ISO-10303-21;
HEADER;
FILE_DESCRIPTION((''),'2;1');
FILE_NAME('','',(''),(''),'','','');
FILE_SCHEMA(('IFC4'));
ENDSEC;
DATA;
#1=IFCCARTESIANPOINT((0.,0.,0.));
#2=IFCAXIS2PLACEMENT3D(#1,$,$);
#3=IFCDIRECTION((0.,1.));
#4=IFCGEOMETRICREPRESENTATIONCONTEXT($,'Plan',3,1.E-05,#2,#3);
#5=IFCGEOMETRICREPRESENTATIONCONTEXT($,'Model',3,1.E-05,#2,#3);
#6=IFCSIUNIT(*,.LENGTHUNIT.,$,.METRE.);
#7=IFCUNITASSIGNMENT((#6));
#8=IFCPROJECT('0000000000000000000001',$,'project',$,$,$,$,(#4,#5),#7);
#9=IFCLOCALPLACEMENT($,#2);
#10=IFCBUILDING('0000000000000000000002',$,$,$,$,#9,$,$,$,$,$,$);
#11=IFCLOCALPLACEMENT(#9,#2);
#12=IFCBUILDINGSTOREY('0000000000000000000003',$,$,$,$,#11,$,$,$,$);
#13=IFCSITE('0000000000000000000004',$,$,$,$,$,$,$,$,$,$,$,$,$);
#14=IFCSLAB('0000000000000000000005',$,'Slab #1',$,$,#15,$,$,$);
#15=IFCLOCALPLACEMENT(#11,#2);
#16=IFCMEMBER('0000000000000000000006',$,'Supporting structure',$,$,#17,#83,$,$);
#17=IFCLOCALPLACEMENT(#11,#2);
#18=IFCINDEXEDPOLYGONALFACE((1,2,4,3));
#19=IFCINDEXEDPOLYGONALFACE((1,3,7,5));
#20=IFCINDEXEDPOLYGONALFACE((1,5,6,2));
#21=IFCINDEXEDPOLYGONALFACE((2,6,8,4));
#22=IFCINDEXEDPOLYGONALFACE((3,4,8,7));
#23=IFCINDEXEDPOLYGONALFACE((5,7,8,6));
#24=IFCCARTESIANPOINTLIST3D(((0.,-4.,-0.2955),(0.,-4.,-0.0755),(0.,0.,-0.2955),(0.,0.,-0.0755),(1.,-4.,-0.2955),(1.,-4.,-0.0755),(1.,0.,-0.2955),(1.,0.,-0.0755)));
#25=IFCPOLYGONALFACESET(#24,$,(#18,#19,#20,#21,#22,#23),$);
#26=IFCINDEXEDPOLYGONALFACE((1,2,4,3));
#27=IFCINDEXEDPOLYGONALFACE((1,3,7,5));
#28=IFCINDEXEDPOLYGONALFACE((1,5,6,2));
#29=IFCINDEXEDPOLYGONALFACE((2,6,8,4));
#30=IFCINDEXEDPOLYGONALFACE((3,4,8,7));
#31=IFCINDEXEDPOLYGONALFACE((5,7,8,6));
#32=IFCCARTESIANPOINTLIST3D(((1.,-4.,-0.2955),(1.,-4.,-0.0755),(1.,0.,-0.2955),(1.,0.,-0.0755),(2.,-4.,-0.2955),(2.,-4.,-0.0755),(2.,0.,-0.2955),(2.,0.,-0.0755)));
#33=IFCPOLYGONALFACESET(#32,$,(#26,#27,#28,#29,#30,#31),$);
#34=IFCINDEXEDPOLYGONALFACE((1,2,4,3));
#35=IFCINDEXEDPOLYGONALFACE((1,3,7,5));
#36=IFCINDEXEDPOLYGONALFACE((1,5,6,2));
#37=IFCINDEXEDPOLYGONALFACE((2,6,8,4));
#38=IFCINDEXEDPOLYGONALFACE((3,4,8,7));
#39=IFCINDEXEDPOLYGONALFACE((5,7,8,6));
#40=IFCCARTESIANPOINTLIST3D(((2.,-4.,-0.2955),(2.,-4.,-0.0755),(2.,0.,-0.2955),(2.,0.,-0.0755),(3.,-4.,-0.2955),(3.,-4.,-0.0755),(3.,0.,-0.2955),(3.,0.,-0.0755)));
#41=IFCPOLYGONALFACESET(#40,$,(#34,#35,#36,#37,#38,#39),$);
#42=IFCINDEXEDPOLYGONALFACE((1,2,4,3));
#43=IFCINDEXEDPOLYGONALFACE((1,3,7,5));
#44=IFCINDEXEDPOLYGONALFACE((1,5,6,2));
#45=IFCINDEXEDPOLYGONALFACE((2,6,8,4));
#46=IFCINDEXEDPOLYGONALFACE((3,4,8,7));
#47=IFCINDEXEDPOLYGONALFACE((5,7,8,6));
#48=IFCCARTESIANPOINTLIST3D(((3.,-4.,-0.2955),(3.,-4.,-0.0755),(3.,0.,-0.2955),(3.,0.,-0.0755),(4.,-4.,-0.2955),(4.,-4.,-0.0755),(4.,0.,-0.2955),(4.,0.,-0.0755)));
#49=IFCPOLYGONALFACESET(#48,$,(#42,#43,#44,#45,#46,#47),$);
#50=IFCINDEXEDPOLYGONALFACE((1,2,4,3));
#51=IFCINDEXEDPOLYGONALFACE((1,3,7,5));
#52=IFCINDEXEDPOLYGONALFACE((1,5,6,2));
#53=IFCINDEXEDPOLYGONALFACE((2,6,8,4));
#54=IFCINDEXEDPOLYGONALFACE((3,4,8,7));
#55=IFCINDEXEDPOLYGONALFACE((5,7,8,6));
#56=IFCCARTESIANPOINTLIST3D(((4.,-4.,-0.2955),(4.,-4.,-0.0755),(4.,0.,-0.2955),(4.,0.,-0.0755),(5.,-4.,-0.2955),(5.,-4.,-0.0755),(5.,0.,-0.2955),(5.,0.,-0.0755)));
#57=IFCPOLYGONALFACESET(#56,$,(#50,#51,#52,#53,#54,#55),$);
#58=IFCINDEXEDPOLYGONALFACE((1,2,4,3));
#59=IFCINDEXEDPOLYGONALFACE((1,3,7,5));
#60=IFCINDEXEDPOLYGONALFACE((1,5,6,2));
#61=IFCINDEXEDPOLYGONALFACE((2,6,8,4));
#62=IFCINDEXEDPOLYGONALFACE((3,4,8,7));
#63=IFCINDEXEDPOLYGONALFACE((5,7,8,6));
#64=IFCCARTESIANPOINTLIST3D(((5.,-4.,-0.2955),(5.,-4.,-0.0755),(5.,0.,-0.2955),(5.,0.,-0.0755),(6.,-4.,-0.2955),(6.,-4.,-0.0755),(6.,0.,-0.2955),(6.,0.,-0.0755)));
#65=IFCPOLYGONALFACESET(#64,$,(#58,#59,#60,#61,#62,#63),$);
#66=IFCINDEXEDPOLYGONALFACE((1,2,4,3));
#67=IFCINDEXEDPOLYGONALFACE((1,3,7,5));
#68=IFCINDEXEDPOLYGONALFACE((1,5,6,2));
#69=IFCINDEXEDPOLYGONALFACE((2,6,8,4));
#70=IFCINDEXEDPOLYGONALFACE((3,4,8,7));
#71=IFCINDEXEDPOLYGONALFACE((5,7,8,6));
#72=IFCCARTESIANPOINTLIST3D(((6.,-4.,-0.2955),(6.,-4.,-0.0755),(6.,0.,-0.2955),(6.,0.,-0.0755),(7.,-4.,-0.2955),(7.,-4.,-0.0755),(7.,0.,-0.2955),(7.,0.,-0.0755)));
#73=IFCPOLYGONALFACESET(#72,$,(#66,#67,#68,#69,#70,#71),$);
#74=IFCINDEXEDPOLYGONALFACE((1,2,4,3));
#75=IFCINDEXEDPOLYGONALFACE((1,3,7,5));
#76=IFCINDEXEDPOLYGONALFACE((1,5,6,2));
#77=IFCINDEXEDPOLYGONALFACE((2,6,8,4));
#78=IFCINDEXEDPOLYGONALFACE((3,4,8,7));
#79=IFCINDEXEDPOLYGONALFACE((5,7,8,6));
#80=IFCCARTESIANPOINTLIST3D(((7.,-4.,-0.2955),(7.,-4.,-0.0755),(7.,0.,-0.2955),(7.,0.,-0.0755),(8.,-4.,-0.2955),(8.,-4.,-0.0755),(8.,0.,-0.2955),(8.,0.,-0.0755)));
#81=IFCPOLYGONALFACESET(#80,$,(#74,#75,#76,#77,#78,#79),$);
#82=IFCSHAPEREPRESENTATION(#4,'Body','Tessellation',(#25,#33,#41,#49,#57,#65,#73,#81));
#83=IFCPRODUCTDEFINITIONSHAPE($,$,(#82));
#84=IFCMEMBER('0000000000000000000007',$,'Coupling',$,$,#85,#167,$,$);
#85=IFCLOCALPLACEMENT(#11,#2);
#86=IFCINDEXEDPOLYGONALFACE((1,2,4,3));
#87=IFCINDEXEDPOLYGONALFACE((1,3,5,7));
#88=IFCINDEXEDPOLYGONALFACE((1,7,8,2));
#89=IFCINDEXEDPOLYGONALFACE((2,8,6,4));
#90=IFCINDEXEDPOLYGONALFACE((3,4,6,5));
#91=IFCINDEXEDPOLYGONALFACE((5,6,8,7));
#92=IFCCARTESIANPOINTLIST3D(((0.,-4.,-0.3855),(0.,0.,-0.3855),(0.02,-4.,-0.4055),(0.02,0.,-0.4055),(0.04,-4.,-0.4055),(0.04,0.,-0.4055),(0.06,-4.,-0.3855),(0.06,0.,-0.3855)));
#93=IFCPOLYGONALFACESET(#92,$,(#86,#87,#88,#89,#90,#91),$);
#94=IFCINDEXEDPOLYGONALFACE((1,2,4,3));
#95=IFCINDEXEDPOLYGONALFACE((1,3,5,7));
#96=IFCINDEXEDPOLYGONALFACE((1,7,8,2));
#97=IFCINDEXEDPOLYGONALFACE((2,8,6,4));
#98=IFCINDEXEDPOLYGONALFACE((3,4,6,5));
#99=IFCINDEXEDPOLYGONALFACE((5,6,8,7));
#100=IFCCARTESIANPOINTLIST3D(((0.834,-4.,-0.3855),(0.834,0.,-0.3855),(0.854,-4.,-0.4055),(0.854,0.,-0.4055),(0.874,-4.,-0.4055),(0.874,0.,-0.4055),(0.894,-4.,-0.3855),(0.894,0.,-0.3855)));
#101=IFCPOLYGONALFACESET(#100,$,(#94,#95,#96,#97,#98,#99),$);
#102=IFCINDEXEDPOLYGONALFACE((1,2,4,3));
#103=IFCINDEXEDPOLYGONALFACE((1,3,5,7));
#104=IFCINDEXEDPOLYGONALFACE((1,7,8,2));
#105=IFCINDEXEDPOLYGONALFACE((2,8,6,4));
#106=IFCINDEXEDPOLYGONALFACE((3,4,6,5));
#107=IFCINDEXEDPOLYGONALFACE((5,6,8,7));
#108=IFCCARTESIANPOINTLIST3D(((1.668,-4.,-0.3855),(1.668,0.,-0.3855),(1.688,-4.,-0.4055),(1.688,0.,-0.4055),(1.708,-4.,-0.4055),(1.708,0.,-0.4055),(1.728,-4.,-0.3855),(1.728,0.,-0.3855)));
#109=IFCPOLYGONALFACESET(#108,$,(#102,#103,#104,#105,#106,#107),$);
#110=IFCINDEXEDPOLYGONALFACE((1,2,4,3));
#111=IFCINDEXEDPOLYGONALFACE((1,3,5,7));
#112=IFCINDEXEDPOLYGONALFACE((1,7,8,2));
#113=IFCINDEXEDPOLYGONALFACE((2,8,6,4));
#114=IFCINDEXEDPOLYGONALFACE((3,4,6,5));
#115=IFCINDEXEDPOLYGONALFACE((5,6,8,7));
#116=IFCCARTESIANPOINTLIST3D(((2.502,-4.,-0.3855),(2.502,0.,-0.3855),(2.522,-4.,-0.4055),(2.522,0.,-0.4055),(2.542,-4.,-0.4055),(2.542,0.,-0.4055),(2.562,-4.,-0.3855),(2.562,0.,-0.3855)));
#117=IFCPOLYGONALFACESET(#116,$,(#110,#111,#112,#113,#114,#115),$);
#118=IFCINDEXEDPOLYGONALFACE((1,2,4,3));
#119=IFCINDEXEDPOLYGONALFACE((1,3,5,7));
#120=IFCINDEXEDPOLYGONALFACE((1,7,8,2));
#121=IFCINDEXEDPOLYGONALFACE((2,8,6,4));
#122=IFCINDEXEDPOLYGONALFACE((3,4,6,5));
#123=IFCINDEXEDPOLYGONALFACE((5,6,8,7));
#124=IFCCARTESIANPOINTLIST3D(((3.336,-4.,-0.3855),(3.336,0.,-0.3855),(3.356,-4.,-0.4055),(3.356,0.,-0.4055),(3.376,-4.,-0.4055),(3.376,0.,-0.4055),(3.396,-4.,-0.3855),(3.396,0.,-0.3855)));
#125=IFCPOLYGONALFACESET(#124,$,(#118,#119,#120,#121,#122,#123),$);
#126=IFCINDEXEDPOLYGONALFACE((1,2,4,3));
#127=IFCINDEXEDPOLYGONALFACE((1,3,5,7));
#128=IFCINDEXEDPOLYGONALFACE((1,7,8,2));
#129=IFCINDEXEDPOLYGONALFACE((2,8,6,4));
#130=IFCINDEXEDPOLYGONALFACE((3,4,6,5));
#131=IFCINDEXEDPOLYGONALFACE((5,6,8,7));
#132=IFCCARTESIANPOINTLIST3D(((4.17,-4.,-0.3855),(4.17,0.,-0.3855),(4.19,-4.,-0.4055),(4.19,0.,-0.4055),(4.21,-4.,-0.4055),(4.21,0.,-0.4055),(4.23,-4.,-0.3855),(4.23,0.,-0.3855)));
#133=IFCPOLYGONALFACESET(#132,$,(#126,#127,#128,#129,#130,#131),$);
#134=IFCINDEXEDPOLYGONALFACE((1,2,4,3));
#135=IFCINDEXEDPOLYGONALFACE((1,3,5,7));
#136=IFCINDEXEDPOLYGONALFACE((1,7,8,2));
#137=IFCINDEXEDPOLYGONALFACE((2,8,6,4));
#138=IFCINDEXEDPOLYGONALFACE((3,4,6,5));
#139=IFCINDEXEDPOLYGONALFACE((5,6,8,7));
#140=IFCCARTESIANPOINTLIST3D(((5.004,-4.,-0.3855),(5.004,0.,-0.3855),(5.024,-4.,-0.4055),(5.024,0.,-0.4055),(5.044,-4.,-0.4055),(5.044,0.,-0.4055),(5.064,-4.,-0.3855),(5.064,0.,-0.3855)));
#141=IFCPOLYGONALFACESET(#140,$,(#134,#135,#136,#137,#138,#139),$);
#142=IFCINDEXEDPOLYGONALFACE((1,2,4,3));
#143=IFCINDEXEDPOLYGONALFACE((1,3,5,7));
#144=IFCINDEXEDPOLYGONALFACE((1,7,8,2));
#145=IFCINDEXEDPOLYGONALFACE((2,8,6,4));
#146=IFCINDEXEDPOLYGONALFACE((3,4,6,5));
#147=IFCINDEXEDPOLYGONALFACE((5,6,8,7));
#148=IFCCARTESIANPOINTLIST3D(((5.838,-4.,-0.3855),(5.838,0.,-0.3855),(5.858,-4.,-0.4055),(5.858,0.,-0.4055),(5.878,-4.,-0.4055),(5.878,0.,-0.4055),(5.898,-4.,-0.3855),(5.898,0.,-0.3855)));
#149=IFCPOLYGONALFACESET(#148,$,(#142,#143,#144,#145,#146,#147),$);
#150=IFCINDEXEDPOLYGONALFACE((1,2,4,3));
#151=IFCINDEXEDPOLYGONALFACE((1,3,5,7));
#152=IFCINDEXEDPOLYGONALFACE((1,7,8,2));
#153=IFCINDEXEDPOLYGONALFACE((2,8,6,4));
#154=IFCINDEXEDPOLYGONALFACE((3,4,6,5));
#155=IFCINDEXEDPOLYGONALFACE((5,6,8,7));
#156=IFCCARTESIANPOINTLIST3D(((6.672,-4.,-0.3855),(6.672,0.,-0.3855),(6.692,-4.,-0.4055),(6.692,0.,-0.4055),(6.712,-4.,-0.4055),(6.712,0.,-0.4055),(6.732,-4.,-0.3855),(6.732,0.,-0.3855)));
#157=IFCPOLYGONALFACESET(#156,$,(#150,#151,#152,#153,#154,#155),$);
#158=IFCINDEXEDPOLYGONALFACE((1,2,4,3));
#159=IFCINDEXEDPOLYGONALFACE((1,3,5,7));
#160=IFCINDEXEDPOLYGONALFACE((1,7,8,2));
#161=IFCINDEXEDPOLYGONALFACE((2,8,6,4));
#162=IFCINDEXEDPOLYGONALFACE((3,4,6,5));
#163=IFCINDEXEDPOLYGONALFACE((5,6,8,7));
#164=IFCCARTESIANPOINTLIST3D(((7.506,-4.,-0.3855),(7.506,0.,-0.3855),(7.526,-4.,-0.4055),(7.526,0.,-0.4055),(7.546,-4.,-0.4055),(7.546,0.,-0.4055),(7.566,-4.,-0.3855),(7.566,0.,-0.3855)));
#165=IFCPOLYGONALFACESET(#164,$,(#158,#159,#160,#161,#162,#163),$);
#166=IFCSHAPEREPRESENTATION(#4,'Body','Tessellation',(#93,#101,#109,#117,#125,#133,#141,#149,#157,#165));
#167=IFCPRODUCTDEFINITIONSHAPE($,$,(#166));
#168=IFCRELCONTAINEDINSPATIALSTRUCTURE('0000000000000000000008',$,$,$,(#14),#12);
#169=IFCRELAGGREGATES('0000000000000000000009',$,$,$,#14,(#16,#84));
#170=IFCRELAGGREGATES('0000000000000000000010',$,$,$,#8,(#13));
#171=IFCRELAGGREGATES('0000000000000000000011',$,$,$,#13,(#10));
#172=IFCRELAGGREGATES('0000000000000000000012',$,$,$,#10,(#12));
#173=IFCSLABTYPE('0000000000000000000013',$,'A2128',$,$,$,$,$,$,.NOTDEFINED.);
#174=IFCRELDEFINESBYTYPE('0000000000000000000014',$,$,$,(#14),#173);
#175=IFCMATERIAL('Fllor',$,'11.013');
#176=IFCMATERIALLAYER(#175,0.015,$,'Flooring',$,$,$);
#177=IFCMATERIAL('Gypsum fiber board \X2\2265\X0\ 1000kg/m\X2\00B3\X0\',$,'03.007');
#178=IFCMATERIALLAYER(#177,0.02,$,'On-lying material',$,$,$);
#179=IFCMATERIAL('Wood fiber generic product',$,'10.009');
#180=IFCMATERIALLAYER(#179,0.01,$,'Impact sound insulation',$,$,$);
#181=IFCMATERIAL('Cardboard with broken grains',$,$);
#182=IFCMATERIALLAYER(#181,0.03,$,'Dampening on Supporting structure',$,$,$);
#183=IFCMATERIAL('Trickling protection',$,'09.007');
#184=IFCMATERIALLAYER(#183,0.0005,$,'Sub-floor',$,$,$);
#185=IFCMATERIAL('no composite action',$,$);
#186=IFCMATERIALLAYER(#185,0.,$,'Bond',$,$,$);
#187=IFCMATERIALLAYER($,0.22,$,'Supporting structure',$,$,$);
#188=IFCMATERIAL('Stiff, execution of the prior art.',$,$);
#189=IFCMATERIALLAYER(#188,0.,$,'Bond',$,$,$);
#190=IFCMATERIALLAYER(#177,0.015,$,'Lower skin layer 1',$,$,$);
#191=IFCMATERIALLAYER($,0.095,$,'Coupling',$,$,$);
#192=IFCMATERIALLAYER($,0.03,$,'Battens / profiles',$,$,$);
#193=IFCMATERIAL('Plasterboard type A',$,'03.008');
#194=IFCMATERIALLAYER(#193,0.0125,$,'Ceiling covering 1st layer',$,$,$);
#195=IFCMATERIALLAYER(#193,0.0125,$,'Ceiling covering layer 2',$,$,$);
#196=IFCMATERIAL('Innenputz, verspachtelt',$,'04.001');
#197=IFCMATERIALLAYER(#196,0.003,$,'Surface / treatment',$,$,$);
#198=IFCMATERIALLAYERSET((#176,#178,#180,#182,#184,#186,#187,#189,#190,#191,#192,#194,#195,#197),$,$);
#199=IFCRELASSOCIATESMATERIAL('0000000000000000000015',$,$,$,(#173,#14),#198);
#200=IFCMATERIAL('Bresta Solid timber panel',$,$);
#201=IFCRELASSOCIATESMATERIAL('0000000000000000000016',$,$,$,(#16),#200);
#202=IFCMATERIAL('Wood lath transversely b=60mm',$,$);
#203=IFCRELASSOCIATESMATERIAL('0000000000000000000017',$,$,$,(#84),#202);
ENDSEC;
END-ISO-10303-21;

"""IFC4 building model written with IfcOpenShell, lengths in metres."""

from ifc_helpers import new_model, si_unit, direction, frame, frame_2d, origin, place, context, project, spatial, polyline, rectangle, outline, extrude, material, layer, layer_set, type_object, element, aggregate, save


model = new_model("IFC4")

# Units and contexts
plan_context = context("Plan", 3, precision=1e-05, world=origin(), true_north=direction((0.0, 1.0)))
model_context = context("Model", 3, precision=1e-05, world=origin(), true_north=direction((0.0, 1.0)))
ifc_project = project(units=[si_unit("LENGTHUNIT", "METRE")], contexts=[plan_context, model_context])

# Site, building, storey
site = spatial("IfcSite", under=ifc_project)
building_placement = place(None, origin())
building = spatial("IfcBuilding", under=site, at=building_placement)
storey_placement = place(building_placement, origin())
storey = spatial("IfcBuildingStorey", under=building, at=storey_placement)

# Slab, members
ifc_material_1 = material(Name="Fllor", Category="11.013")
ifc_layer_1 = layer(ifc_material_1, 0.015, Name="Flooring")
ifc_material_2 = material(Name="Gypsum fiber board ≥ 1000kg/m³", Category="03.007")
ifc_layer_2 = layer(ifc_material_2, 0.02, Name="On-lying material")
ifc_material_3 = material(Name="Wood fiber generic product", Category="10.009")
ifc_layer_3 = layer(ifc_material_3, 0.01, Name="Impact sound insulation")
ifc_material_4 = material(Name="Cardboard with broken grains")
ifc_layer_4 = layer(ifc_material_4, 0.03, Name="Dampening on Supporting structure")
ifc_material_5 = material(Name="Trickling protection", Category="09.007")
ifc_layer_5 = layer(ifc_material_5, 0.0005, Name="Sub-floor")
ifc_material_6 = material(Name="no composite action")
ifc_layer_6 = layer(ifc_material_6, 0.0, Name="Bond")
ifc_layer_7 = layer(None, 0.22, Name="Supporting structure")
ifc_material_7 = material(Name="Stiff, execution of the prior art.")
ifc_layer_8 = layer(ifc_material_7, 0.0, Name="Bond")
ifc_layer_9 = layer(ifc_material_2, 0.015, Name="Lower skin layer 1")
ifc_layer_10 = layer(None, 0.095, Name="Coupling")
ifc_layer_11 = layer(None, 0.03, Name="Battens / profiles")
ifc_material_8 = material(Name="Plasterboard type A", Category="03.008")
ifc_layer_12 = layer(ifc_material_8, 0.0125, Name="Ceiling covering 1st layer")
ifc_layer_13 = layer(ifc_material_8, 0.0125, Name="Ceiling covering layer 2")
ifc_material_9 = material(Name="Innenputz, verspachtelt", Category="04.001")
ifc_layer_14 = layer(ifc_material_9, 0.003, Name="Surface / treatment")
ifc_layer_set = layer_set([ifc_layer_1, ifc_layer_2, ifc_layer_3, ifc_layer_4, ifc_layer_5, ifc_layer_6, ifc_layer_7, ifc_layer_8, ifc_layer_9, ifc_layer_10, ifc_layer_11, ifc_layer_12, ifc_layer_13, ifc_layer_14])
slab_type = type_object("IfcSlabType", Name="A2128", PredefinedType="NOTDEFINED", material=ifc_layer_set)
slab_placement = place(None, frame((0.0, 0.0, 0.0), z_axis=(0.0, 0.0, -1.0), x_axis=(1.0, 0.0, 0.0)))
slab = element("IfcSlab", 1, at=slab_placement, inside=storey, type_object=slab_type, material=ifc_layer_set, Name="Slab #1")
ifc_material_10 = material(Name="Bresta Solid timber panel")
member_1_placement = place(slab_placement, origin())
member_1 = element("IfcMember", 2, at=member_1_placement, material=ifc_material_10, Name="Supporting structure", context=plan_context, shape_type="SweptSolid", body=[
    extrude(rectangle(XDim=1.0, YDim=0.22, at=frame_2d((0.5, 0.11), x_axis=(1.0, 0.0))), frame((0.0, 4.0, 0.0755), z_axis=(0.0, -1.0, 0.0), x_axis=(1.0, 0.0, 0.0)), (0.0, 0.0, 1.0), 4.0),
    extrude(rectangle(XDim=1.0, YDim=0.22, at=frame_2d((0.5, 0.11), x_axis=(1.0, 0.0))), frame((1.0, 4.0, 0.0755), z_axis=(0.0, -1.0, 0.0), x_axis=(1.0, 0.0, 0.0)), (0.0, 0.0, 1.0), 4.0),
    extrude(rectangle(XDim=1.0, YDim=0.22, at=frame_2d((0.5, 0.11), x_axis=(1.0, 0.0))), frame((2.0, 4.0, 0.0755), z_axis=(0.0, -1.0, 0.0), x_axis=(1.0, 0.0, 0.0)), (0.0, 0.0, 1.0), 4.0),
    extrude(rectangle(XDim=1.0, YDim=0.22, at=frame_2d((0.5, 0.11), x_axis=(1.0, 0.0))), frame((3.0, 4.0, 0.0755), z_axis=(0.0, -1.0, 0.0), x_axis=(1.0, 0.0, 0.0)), (0.0, 0.0, 1.0), 4.0),
    extrude(rectangle(XDim=1.0, YDim=0.22, at=frame_2d((0.5, 0.11), x_axis=(1.0, 0.0))), frame((4.0, 4.0, 0.0755), z_axis=(0.0, -1.0, 0.0), x_axis=(1.0, 0.0, 0.0)), (0.0, 0.0, 1.0), 4.0),
    extrude(rectangle(XDim=1.0, YDim=0.22, at=frame_2d((0.5, 0.11), x_axis=(1.0, 0.0))), frame((5.0, 4.0, 0.0755), z_axis=(0.0, -1.0, 0.0), x_axis=(1.0, 0.0, 0.0)), (0.0, 0.0, 1.0), 4.0),
    extrude(rectangle(XDim=1.0, YDim=0.22, at=frame_2d((0.5, 0.11), x_axis=(1.0, 0.0))), frame((6.0, 4.0, 0.0755), z_axis=(0.0, -1.0, 0.0), x_axis=(1.0, 0.0, 0.0)), (0.0, 0.0, 1.0), 4.0),
    extrude(rectangle(XDim=1.0, YDim=0.22, at=frame_2d((0.5, 0.11), x_axis=(1.0, 0.0))), frame((7.0, 4.0, 0.0755), z_axis=(0.0, -1.0, 0.0), x_axis=(1.0, 0.0, 0.0)), (0.0, 0.0, 1.0), 4.0),
])
ifc_material_11 = material(Name="Wood lath transversely b=60mm")
member_2_placement = place(slab_placement, origin())
member_2 = element("IfcMember", 3, at=member_2_placement, material=ifc_material_11, Name="Coupling", context=plan_context, shape_type="SweptSolid", body=[
    extrude(outline(polyline([(0.0, 0.0), (0.06, 0.0), (0.04, 0.02), (0.02, 0.02), (0.0, 0.0)])), frame((0.0, 4.0, 0.3855), z_axis=(0.0, -1.0, 0.0), x_axis=(1.0, 0.0, 0.0)), (0.0, 0.0, 1.0), 4.0),
    extrude(outline(polyline([(0.0, 0.0), (0.06, 0.0), (0.04, 0.02), (0.02, 0.02), (0.0, 0.0)])), frame((0.834, 4.0, 0.3855), z_axis=(0.0, -1.0, 0.0), x_axis=(1.0, 0.0, 0.0)), (0.0, 0.0, 1.0), 4.0),
    extrude(outline(polyline([(0.0, 0.0), (0.06, 0.0), (0.04, 0.02), (0.02, 0.02), (0.0, 0.0)])), frame((1.668, 4.0, 0.3855), z_axis=(0.0, -1.0, 0.0), x_axis=(1.0, 0.0, 0.0)), (0.0, 0.0, 1.0), 4.0),
    extrude(outline(polyline([(0.0, 0.0), (0.06, 0.0), (0.04, 0.02), (0.02, 0.02), (0.0, 0.0)])), frame((2.502, 4.0, 0.3855), z_axis=(0.0, -1.0, 0.0), x_axis=(1.0, 0.0, 0.0)), (0.0, 0.0, 1.0), 4.0),
    extrude(outline(polyline([(0.0, 0.0), (0.06, 0.0), (0.04, 0.02), (0.02, 0.02), (0.0, 0.0)])), frame((3.336, 4.0, 0.3855), z_axis=(0.0, -1.0, 0.0), x_axis=(1.0, 0.0, 0.0)), (0.0, 0.0, 1.0), 4.0),
    extrude(outline(polyline([(0.0, 0.0), (0.06, 0.0), (0.04, 0.02), (0.02, 0.02), (0.0, 0.0)])), frame((4.17, 4.0, 0.3855), z_axis=(0.0, -1.0, 0.0), x_axis=(1.0, 0.0, 0.0)), (0.0, 0.0, 1.0), 4.0),
    extrude(outline(polyline([(0.0, 0.0), (0.06, 0.0), (0.04, 0.02), (0.02, 0.02), (0.0, 0.0)])), frame((5.004, 4.0, 0.3855), z_axis=(0.0, -1.0, 0.0), x_axis=(1.0, 0.0, 0.0)), (0.0, 0.0, 1.0), 4.0),
    extrude(outline(polyline([(0.0, 0.0), (0.06, 0.0), (0.04, 0.02), (0.02, 0.02), (0.0, 0.0)])), frame((5.838, 4.0, 0.3855), z_axis=(0.0, -1.0, 0.0), x_axis=(1.0, 0.0, 0.0)), (0.0, 0.0, 1.0), 4.0),
    extrude(outline(polyline([(0.0, 0.0), (0.06, 0.0), (0.04, 0.02), (0.02, 0.02), (0.0, 0.0)])), frame((6.672, 4.0, 0.3855), z_axis=(0.0, -1.0, 0.0), x_axis=(1.0, 0.0, 0.0)), (0.0, 0.0, 1.0), 4.0),
    extrude(outline(polyline([(0.0, 0.0), (0.06, 0.0), (0.04, 0.02), (0.02, 0.02), (0.0, 0.0)])), frame((7.506, 4.0, 0.3855), z_axis=(0.0, -1.0, 0.0), x_axis=(1.0, 0.0, 0.0)), (0.0, 0.0, 1.0), 4.0),
])
aggregate(slab, [member_1, member_2])

save(model, "model.ifc")
